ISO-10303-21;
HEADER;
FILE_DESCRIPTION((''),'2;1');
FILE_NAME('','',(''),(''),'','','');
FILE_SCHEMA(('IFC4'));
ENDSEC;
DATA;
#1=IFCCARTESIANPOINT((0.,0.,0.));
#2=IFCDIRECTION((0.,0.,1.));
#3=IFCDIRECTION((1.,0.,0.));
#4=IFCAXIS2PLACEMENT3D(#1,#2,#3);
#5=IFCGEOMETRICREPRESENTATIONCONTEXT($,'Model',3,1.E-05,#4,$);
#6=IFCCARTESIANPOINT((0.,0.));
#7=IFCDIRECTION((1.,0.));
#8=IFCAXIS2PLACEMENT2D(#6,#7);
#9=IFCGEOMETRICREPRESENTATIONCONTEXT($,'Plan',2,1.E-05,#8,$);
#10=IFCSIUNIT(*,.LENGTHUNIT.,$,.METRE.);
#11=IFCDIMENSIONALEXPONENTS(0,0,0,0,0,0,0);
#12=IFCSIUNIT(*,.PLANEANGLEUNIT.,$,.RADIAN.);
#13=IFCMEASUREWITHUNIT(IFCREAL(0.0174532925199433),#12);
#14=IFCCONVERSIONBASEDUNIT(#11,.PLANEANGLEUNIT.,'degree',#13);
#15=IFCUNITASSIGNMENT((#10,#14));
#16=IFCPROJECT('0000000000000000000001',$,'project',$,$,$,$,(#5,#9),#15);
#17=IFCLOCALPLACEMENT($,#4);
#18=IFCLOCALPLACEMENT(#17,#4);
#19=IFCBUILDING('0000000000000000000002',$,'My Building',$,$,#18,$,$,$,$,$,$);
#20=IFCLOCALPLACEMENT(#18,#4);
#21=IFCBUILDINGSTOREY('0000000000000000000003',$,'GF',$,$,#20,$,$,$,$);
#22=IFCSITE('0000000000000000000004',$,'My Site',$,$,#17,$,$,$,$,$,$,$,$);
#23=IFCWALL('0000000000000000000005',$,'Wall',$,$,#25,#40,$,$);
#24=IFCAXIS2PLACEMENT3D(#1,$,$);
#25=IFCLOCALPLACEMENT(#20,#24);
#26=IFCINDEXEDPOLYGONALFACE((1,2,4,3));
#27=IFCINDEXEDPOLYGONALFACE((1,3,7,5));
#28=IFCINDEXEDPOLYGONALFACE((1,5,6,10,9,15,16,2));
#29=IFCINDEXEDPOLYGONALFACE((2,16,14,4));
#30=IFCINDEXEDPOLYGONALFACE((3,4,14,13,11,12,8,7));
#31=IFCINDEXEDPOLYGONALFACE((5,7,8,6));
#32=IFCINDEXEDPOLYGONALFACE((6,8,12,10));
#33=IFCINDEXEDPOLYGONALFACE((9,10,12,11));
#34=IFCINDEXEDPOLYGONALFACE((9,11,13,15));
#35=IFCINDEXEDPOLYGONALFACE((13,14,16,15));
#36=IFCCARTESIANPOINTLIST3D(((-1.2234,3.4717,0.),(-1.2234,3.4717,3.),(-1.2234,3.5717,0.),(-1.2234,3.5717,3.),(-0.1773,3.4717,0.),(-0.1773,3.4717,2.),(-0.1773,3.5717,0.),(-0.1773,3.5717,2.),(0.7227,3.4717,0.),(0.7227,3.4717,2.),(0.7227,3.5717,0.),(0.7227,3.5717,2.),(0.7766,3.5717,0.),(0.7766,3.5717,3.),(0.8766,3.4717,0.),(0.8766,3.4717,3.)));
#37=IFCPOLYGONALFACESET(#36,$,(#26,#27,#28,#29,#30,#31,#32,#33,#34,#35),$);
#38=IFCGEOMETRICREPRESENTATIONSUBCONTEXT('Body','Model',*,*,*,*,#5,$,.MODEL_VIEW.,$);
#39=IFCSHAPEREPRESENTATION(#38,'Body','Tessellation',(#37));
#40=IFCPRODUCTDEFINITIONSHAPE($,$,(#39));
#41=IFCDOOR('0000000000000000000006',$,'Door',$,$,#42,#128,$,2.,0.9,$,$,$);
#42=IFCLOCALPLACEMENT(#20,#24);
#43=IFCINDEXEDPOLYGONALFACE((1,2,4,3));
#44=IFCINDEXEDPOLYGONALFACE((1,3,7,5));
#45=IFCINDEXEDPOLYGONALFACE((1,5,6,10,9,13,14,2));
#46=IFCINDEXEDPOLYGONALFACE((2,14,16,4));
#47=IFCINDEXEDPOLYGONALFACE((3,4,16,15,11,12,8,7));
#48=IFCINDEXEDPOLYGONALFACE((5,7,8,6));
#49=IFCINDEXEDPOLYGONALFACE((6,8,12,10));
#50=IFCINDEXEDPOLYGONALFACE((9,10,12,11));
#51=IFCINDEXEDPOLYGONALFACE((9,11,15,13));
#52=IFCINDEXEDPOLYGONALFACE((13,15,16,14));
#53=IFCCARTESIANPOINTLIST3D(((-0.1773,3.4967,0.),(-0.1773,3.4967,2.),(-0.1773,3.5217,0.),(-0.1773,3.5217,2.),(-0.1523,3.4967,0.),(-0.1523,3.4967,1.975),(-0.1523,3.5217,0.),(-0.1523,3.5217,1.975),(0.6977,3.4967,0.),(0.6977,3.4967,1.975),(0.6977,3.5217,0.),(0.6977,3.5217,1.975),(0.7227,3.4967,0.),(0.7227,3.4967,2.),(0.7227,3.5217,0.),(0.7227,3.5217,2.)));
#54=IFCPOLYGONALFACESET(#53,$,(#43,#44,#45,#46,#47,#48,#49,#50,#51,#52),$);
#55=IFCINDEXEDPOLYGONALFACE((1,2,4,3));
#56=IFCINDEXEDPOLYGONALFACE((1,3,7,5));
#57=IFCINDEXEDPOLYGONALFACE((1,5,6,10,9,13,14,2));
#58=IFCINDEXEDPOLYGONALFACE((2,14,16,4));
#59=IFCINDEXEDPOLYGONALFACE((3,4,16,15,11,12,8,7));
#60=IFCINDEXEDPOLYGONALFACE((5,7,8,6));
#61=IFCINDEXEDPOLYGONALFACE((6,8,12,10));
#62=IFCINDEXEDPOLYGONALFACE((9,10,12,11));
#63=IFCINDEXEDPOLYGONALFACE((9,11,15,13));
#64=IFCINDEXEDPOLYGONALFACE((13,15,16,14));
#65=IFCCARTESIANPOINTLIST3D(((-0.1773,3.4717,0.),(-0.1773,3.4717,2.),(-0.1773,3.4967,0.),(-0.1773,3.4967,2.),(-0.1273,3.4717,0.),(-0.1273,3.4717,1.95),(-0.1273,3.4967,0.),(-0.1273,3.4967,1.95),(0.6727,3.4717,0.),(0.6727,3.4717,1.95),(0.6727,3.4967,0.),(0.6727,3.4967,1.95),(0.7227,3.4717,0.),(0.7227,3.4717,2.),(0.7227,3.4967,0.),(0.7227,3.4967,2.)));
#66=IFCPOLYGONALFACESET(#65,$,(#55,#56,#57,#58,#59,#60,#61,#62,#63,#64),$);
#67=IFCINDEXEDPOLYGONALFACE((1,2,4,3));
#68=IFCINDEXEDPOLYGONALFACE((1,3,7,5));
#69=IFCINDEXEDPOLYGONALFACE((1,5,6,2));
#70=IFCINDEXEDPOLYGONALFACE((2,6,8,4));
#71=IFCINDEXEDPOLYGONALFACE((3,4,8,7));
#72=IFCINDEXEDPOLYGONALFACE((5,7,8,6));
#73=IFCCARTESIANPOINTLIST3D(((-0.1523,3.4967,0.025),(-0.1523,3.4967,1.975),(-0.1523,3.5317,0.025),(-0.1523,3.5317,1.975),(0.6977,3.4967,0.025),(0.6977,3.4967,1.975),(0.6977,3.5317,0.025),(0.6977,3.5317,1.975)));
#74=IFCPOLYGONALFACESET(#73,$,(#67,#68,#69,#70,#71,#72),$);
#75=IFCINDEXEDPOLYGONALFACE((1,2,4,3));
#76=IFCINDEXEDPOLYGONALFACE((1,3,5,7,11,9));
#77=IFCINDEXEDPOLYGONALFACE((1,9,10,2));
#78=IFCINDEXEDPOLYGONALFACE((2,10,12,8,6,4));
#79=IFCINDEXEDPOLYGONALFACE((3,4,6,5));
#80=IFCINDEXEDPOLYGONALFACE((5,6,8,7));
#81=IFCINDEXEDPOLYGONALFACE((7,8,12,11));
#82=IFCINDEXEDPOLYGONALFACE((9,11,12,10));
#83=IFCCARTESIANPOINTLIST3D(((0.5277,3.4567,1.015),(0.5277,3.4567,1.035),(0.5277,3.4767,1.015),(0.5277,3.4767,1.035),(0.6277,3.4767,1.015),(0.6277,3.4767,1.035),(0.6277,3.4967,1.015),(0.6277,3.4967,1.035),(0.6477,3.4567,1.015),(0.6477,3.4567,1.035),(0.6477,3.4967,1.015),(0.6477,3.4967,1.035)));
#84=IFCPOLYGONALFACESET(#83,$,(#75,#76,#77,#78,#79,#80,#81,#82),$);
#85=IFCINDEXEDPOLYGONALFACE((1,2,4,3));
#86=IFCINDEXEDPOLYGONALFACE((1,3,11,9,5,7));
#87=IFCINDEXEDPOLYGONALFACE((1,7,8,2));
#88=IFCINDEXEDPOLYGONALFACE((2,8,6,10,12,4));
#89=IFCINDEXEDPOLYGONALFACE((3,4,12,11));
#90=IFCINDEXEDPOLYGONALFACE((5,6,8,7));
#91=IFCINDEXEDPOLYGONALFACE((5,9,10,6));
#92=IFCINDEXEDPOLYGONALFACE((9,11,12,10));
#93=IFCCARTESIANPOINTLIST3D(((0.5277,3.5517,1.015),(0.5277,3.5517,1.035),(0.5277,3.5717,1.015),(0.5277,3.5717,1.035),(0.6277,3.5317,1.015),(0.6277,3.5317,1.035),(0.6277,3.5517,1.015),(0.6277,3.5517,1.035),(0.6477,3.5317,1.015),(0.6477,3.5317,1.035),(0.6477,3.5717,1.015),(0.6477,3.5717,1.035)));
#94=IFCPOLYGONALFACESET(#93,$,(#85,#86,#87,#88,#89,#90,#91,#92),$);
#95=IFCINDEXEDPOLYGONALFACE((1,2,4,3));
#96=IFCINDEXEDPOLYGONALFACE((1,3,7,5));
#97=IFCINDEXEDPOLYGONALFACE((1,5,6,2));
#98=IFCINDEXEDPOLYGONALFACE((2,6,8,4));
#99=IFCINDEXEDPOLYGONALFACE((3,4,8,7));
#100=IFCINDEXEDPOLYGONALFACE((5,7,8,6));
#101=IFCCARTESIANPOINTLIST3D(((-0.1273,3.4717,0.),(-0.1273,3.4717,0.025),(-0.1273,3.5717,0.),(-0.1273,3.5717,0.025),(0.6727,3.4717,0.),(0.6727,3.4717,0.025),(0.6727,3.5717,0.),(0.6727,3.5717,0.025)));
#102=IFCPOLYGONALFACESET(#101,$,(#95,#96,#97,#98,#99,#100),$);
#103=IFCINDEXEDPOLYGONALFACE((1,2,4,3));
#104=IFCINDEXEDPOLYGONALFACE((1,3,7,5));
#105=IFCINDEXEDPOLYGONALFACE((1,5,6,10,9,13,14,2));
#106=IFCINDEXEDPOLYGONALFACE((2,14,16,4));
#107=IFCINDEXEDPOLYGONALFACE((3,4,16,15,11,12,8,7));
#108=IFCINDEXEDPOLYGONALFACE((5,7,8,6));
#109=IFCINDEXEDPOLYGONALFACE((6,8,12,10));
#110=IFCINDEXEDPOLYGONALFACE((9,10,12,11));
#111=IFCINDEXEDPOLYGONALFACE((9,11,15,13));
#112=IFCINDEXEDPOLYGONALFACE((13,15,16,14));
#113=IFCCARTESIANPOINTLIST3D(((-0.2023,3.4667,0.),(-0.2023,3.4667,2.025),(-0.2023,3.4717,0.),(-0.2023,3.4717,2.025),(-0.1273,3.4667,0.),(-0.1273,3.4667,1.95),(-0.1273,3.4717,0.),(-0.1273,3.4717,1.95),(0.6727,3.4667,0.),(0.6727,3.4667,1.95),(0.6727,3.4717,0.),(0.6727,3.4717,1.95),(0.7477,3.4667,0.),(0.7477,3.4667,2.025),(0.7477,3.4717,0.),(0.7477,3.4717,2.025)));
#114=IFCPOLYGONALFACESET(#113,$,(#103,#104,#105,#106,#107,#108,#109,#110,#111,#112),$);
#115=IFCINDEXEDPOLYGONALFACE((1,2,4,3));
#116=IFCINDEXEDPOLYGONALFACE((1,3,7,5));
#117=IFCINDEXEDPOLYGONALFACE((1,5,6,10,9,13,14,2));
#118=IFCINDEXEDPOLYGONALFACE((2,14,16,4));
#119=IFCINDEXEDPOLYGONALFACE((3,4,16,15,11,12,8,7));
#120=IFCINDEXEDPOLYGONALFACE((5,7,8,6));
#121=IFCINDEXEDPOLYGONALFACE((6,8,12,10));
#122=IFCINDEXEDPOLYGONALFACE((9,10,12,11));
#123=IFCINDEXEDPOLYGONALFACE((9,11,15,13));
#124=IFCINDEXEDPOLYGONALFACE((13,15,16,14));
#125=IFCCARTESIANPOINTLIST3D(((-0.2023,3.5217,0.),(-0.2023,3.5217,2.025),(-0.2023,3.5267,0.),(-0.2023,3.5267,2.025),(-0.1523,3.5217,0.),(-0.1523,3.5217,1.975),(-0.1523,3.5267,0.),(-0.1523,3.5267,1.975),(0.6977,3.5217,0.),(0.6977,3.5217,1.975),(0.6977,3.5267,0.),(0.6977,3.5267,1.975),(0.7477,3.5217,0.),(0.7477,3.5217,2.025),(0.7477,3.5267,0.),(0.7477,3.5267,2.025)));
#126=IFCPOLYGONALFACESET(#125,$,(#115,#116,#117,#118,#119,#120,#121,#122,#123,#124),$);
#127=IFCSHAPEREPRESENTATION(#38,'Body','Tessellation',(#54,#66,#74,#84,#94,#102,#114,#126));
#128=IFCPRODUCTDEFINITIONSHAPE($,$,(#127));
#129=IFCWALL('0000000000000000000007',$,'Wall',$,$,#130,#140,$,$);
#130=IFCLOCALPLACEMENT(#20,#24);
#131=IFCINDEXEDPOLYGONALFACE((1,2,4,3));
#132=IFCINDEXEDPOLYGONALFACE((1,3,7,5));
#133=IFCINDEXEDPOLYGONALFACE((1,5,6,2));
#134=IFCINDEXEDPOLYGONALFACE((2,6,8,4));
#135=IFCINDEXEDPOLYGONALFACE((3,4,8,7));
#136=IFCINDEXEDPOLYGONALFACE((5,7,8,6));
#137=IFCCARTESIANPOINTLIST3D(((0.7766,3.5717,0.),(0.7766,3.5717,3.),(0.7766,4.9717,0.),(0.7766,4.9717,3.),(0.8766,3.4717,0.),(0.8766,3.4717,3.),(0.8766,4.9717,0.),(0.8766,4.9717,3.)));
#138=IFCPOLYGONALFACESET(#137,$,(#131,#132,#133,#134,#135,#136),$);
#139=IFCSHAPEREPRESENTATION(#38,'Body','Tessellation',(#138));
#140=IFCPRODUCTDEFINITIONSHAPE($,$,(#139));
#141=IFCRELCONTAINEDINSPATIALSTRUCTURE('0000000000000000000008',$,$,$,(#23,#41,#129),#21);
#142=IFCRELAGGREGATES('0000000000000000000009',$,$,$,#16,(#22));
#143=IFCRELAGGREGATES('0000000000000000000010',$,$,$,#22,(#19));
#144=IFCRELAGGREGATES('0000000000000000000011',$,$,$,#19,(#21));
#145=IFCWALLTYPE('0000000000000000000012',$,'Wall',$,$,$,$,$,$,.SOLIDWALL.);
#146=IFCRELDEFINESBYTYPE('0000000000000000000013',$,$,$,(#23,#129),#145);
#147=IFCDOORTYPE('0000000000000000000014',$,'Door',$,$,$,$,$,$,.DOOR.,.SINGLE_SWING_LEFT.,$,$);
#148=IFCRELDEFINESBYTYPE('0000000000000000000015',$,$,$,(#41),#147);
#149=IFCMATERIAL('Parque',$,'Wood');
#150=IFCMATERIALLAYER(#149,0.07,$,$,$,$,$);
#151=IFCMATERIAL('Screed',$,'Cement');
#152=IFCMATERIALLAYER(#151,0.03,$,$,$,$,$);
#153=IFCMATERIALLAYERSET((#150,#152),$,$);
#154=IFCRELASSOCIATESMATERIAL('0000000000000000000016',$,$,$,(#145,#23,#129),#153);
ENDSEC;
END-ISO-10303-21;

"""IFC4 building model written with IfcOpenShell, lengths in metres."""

from ifc_helpers import new_model, entity, si_unit, converted_unit, frame, origin_with_axes, origin_2d_with_axis, place, context, subcontext, project, spatial, line, indexed_curve, outline, extrude, shape, source, transform, mapped, material, layer, layer_set, layer_usage, type_object, type_shapes, element, fill, save


model = new_model("IFC4")

# Units and contexts
model_context = context("Model", 3, precision=1e-05, world=origin_with_axes())
plan_context = context("Plan", 2, precision=1e-05, world=origin_2d_with_axis())
body_context_1 = subcontext(model_context, "Body", "Model", "MODEL_VIEW")
body_context_2 = subcontext(plan_context, "Body", "Plan", "PLAN_VIEW")
ifc_project = project(units=[si_unit("LENGTHUNIT", "METRE"), converted_unit("PLANEANGLEUNIT", "degree", entity("IfcReal", 0.0174532925199433), si_unit("PLANEANGLEUNIT", "RADIAN"), dimensions=[0, 0, 0, 0, 0, 0, 0])], contexts=[model_context, plan_context])

# Site, building, storey
site_placement = place(None, origin_with_axes())
site = spatial("IfcSite", under=ifc_project, at=site_placement, Name="My Site")
building_placement = place(site_placement, origin_with_axes())
building = spatial("IfcBuilding", under=site, at=building_placement, Name="My Building")
storey_placement = place(building_placement, origin_with_axes())
storey = spatial("IfcBuildingStorey", under=building, at=storey_placement, Name="GF")

# Shared definitions
ifc_material_1 = material(Name="Parque", Category="Wood")
ifc_layer_1 = layer(ifc_material_1, 0.07)
ifc_material_2 = material(Name="Screed", Category="Cement")
ifc_layer_2 = layer(ifc_material_2, 0.03)
ifc_layer_set_1 = layer_set([ifc_layer_1, ifc_layer_2])
wall_type = type_object("IfcWallType", Name="Wall", PredefinedType="SOLIDWALL", material=ifc_layer_set_1)
shared_shape_1 = source(origin_with_axes(), body_context_1, "Body", "SweptSolid", [
    extrude(outline(indexed_curve([(0.0, 0.0), (0.9, 0.0), (0.9, 2.0), (0.0, 2.0)], segments=[line(1, 2, 3, 4, 1)])), frame((0.0, -0.6, 0.0), z_axis=(0.0, -1.0, 0.0), x_axis=(1.0, 0.0, 0.0)), (0.0, 0.0, -1.0), 1.2),
])
door_type = type_object("IfcDoorType", Name="Door", OperationType="SINGLE_SWING_LEFT", PredefinedType="DOOR")
shared_shape_2 = source(origin_with_axes(), body_context_1, "Body", "SweptSolid", [
    extrude(outline(indexed_curve([(0.0, 0.0), (0.0, 2.0), (0.9, 2.0), (0.9, 0.0), (0.875, 0.0), (0.875, 1.975), (0.025, 1.975), (0.025, 0.0)], segments=[line(1, 2, 3, 4, 5, 6, 7, 8, 1)])), frame((0.0, 0.025, 0.0), z_axis=(0.0, -1.0, 0.0), x_axis=(1.0, 0.0, 0.0)), (0.0, 0.0, -1.0), 0.025),
    extrude(outline(indexed_curve([(0.0, 0.0), (0.0, 2.0), (0.9, 2.0), (0.9, 0.0), (0.85, 0.0), (0.85, 1.95), (0.05, 1.95), (0.05, 0.0)], segments=[line(1, 2, 3, 4, 5, 6, 7, 8, 1)])), frame((0.0, 0.0, 0.0), z_axis=(0.0, -1.0, 0.0), x_axis=(1.0, 0.0, 0.0)), (0.0, 0.0, -1.0), 0.025),
    extrude(outline(indexed_curve([(0.0, 0.0), (0.85, 0.0), (0.85, 0.035), (0.0, 0.035)], segments=[line(1, 2, 3, 4, 1)])), frame((0.025, 0.025, 0.025), z_axis=(0.0, 0.0, 1.0), x_axis=(1.0, 0.0, 0.0)), (0.0, 0.0, 1.0), 1.95),
    extrude(outline(indexed_curve([(0.0, 0.0), (0.0, -0.04), (-0.12, -0.04), (-0.12, -0.02), (-0.02, -0.02), (-0.02, 0.0)], segments=[line(1, 2, 3, 4, 5, 6, 1)])), frame((0.825, 0.025, 1.015), z_axis=(0.0, 0.0, 1.0), x_axis=(1.0, 0.0, 0.0)), (0.0, 0.0, 1.0), 0.02),
    extrude(outline(indexed_curve([(0.0, 0.0), (0.0, 0.04), (-0.12, 0.04), (-0.12, 0.02), (-0.02, 0.02), (-0.02, 0.0)], segments=[line(1, 2, 3, 4, 5, 6, 1)])), frame((0.825, 0.06, 1.015), z_axis=(0.0, 0.0, 1.0), x_axis=(1.0, 0.0, 0.0)), (0.0, 0.0, 1.0), 0.02),
    extrude(outline(indexed_curve([(0.0, 0.0), (0.8, 0.0), (0.8, 0.1), (0.0, 0.1)], segments=[line(1, 2, 3, 4, 1)])), frame((0.05, 0.0, 0.0), z_axis=(0.0, 0.0, 1.0), x_axis=(1.0, 0.0, 0.0)), (0.0, 0.0, 1.0), 0.025),
    extrude(outline(indexed_curve([(0.0, 0.0), (0.0, 2.025), (0.95, 2.025), (0.95, 0.0), (0.875, 0.0), (0.875, 1.95), (0.075, 1.95), (0.075, 0.0)], segments=[line(1, 2, 3, 4, 5, 6, 7, 8, 1)])), frame((-0.025, -0.005, 0.0), z_axis=(0.0, -1.0, 0.0), x_axis=(1.0, 0.0, 0.0)), (0.0, 0.0, -1.0), 0.005),
    extrude(outline(indexed_curve([(0.0, 0.0), (0.0, 2.025), (0.95, 2.025), (0.95, 0.0), (0.9, 0.0), (0.9, 1.975), (0.05, 1.975), (0.05, 0.0)], segments=[line(1, 2, 3, 4, 5, 6, 7, 8, 1)])), frame((-0.025, 0.05, 0.0), z_axis=(0.0, -1.0, 0.0), x_axis=(1.0, 0.0, 0.0)), (0.0, 0.0, -1.0), 0.005),
])
shared_shape_3 = source(origin_with_axes(), body_context_2, "Body", "Curve2D", [
    entity("IfcIndexedPolyCurve", entity("IfcCartesianPointList2D", [[0.0, 0.0], [0.0, 0.05], [0.025, 0.05], [0.025, 0.025], [0.05, 0.025], [0.05, 0.0]]), [entity("IfcLineIndex", [1, 2, 3, 4, 5, 6, 1])]),
    entity("IfcIndexedPolyCurve", entity("IfcCartesianPointList2D", [[0.9, 0.0], [0.9, 0.05], [0.875, 0.05], [0.875, 0.025], [0.85, 0.025], [0.85, 0.0]]), [entity("IfcLineIndex", [1, 2, 3, 4, 5, 6, 1])]),
    entity("IfcTrimmedCurve", entity("IfcEllipse", entity("IfcAxis2Placement2D", entity("IfcCartesianPoint", [0.06, 0.05]), entity("IfcDirection", [1.0, 0.0])), 0.815, 0.85), [entity("IfcCartesianPoint", [0.875, 0.05])], [entity("IfcCartesianPoint", [0.06, 0.9])], True, "CARTESIAN"),
    entity("IfcIndexedPolyCurve", entity("IfcCartesianPointList2D", [[0.025, 0.05], [0.06, 0.05], [0.06, 0.9], [0.025, 0.9]]), [entity("IfcLineIndex", [1, 2, 3, 4, 1])]),
])
type_shapes(door_type, [shared_shape_2, shared_shape_3])

# Wall, opening, door
ifc_layer_usage_1 = layer_usage(ifc_layer_set_1, "AXIS2", "POSITIVE", 0.0)
wall_1_placement = place(storey_placement, frame((-1.2234, 3.4717, 0.0), z_axis=(0.0, 0.0, 1.0), x_axis=(1.0, 0.0, 0.0)))
wall_1 = element("IfcWall", 1, at=wall_1_placement, inside=storey, type_object=wall_type, material=ifc_layer_usage_1, Name="Wall", context=body_context_1, shape_type="SweptSolid", body=[
    extrude(outline(indexed_curve([(0.0, 0.0), (0.0, 0.1), (2.0, 0.1), (2.1, 0.0)], segments=[line(1, 2, 3, 4, 1)])), origin_with_axes(), (0.0, 0.0, 1.0), 3.0),
])
opening_1_placement = place(wall_1_placement, frame((1.046, 0.0, 0.0), z_axis=(0.0, 0.0, 1.0), x_axis=(1.0, 0.0, 0.0)))
opening_1 = element("IfcOpeningElement", 2, at=opening_1_placement, cuts=wall_1, PredefinedType="OPENING", context=body_context_1, shape_type="MappedRepresentation", body=[
    mapped(shared_shape_1, transform((0.0, 0.0, 0.0), x_axis=(1.0, 0.0, 0.0), y_axis=(0.0, 1.0, 0.0), z_axis=(0.0, 0.0, 1.0), scale=1.0)),
])
door_1_placement = place(opening_1_placement, origin_with_axes())
door_1 = element("IfcDoor", 3, at=door_1_placement, inside=storey, type_object=door_type, Name="Door", OverallHeight=2.0, OverallWidth=0.9, shapes=[
    shape(body_context_1, "Body", "MappedRepresentation", [mapped(shared_shape_2, transform((0.0, 0.0, 0.0), x_axis=(1.0, 0.0, 0.0), y_axis=(0.0, 1.0, 0.0), z_axis=(0.0, 0.0, 1.0), scale=1.0))]),
    shape(body_context_2, "Body", "MappedRepresentation", [mapped(shared_shape_3, transform((0.0, 0.0, 0.0), x_axis=(1.0, 0.0, 0.0), y_axis=(0.0, 1.0, 0.0), z_axis=(0.0, 0.0, 1.0), scale=1.0))]),
])
fill(opening_1, door_1)

# Wall
ifc_layer_usage_2 = layer_usage(ifc_layer_set_1, "AXIS2", "POSITIVE", 0.0)
wall_2_placement = place(storey_placement, frame((0.8766, 3.4717, 0.0), z_axis=(0.0, 0.0, 1.0), x_axis=(0.0, 1.0, 0.0)))
element("IfcWall", 4, at=wall_2_placement, inside=storey, type_object=wall_type, material=ifc_layer_usage_2, Name="Wall", context=body_context_1, shape_type="SweptSolid", body=[
    extrude(outline(indexed_curve([(0.0, 0.0), (0.1, 0.1), (1.5, 0.1), (1.5, 0.0)], segments=[line(1, 2, 3, 4, 1)])), origin_with_axes(), (0.0, 0.0, 1.0), 3.0),
])

save(model, "model.ifc")
